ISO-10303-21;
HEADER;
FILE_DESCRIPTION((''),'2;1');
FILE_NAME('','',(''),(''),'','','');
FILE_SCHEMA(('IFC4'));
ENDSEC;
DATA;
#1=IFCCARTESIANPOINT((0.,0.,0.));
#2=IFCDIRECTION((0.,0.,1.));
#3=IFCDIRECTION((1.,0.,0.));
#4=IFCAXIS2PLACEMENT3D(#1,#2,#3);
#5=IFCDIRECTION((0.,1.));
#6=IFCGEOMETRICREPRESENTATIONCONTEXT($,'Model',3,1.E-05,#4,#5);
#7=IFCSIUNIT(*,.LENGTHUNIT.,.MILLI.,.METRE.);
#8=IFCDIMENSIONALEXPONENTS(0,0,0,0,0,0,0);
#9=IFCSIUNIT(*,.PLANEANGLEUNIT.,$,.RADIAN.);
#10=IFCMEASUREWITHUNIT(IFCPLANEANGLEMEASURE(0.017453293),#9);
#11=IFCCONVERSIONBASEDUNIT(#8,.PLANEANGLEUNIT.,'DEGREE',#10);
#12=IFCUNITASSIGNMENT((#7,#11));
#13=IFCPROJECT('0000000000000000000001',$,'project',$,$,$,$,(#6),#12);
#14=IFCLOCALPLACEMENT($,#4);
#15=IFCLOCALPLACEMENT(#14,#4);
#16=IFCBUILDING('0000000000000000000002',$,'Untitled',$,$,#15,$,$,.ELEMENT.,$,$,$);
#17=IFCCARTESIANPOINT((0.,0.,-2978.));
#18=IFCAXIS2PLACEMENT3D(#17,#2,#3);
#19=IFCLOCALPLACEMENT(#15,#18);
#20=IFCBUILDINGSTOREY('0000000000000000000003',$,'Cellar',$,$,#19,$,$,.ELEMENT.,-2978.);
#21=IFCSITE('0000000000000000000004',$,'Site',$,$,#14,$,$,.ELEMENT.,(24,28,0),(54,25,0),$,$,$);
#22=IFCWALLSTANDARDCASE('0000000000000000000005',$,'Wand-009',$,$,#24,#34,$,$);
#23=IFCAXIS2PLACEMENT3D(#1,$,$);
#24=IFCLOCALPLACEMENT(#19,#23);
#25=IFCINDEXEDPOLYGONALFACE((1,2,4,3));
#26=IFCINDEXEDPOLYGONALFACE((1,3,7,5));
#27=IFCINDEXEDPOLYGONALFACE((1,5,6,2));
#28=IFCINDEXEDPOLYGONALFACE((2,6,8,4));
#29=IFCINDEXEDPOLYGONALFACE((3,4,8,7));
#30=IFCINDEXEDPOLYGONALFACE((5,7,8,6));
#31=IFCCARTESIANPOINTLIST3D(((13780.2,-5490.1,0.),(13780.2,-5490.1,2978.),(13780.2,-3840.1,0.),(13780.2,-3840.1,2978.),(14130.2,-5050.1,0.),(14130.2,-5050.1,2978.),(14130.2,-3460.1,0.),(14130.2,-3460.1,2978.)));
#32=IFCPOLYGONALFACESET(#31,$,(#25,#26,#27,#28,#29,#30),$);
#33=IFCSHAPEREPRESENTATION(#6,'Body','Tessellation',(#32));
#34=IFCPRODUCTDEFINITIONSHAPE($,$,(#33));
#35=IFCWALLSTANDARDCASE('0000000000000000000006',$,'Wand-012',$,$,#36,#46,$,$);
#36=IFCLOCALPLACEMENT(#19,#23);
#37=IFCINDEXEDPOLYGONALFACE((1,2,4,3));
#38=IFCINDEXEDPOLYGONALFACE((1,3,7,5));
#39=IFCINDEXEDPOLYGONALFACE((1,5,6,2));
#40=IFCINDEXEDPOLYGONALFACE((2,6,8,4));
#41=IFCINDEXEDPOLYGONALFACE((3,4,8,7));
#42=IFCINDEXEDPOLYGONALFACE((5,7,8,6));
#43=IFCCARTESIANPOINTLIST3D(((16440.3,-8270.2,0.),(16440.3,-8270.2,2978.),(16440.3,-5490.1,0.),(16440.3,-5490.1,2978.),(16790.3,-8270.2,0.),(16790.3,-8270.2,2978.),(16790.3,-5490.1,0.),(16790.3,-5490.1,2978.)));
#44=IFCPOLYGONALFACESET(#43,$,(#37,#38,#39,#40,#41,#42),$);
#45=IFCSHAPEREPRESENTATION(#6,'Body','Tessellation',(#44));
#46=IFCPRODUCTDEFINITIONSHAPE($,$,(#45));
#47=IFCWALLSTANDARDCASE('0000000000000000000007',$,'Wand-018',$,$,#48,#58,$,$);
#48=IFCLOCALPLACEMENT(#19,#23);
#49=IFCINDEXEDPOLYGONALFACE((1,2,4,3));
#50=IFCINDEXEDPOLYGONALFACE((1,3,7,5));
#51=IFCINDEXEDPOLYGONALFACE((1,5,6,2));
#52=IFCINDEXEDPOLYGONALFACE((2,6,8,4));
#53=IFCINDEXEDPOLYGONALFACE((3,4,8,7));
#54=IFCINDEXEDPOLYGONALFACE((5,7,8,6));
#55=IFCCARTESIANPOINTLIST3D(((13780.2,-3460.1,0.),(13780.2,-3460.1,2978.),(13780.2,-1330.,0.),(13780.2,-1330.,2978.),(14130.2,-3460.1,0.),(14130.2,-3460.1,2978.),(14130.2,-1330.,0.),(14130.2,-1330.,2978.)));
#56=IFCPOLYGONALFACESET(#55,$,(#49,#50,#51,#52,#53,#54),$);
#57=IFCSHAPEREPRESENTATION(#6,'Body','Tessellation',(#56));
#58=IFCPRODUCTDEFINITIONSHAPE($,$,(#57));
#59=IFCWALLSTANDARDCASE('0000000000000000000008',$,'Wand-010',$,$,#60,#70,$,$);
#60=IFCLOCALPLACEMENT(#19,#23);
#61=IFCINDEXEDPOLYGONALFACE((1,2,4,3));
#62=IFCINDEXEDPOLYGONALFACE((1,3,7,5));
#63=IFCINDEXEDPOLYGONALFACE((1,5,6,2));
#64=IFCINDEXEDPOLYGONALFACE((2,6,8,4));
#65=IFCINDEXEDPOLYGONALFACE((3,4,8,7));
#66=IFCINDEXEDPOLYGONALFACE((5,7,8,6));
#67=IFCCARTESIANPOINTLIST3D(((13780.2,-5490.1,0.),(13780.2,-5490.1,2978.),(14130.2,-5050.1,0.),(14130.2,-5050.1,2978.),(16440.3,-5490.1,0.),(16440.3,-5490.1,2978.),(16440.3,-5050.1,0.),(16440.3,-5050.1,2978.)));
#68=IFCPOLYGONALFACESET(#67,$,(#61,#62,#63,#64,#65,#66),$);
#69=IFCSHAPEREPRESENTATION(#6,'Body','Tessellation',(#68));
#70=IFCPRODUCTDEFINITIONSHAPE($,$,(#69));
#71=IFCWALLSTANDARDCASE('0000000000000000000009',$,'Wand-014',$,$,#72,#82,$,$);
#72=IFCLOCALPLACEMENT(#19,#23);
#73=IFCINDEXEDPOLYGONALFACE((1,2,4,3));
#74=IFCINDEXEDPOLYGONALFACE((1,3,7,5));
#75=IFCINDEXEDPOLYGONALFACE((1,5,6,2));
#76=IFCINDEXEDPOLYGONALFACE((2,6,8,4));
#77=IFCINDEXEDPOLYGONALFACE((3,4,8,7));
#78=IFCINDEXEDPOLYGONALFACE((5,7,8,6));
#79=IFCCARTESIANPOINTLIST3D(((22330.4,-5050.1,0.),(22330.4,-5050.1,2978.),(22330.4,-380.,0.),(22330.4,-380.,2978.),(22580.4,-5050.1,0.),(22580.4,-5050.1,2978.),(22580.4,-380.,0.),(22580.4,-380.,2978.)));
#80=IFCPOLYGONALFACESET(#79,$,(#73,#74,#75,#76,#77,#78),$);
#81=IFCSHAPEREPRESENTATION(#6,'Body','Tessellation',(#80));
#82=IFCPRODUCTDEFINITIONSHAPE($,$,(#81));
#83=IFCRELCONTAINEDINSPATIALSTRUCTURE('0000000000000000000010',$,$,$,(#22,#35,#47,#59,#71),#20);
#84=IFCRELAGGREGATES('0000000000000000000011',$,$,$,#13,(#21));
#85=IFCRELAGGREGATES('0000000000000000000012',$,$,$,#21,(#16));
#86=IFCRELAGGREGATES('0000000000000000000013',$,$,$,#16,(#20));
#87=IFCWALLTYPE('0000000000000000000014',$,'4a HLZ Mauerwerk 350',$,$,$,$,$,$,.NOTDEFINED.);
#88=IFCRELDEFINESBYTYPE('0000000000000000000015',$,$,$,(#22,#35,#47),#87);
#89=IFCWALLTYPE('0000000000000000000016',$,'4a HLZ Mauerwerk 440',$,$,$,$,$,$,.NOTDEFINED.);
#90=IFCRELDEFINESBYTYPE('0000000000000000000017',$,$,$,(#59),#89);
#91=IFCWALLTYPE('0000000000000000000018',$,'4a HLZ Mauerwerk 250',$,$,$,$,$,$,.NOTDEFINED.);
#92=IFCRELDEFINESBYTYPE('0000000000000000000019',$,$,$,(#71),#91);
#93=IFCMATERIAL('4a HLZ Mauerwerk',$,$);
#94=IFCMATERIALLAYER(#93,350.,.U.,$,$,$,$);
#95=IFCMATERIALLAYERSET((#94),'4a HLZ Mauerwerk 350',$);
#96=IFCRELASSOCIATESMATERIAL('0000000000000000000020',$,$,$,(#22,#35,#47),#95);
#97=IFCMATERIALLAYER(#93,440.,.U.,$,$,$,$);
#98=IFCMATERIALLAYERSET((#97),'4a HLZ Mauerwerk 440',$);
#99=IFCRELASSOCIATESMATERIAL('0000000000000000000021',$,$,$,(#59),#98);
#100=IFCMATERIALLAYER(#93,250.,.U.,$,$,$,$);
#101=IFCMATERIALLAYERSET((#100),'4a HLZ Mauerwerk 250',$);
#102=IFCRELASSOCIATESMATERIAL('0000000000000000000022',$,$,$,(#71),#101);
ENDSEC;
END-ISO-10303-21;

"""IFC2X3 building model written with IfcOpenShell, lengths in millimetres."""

from ifc_helpers import new_model, entity, si_unit, converted_unit, direction, frame, origin_with_axes, place, context, project, spatial, polyline, outline, extrude, material, layer, layer_set, layer_usage, type_object, element, save


model = new_model("IFC2X3")

# Units and contexts
model_context = context("Model", 3, precision=1e-05, world=origin_with_axes(), true_north=direction((0.0, 1.0)))
ifc_project = project(units=[si_unit("LENGTHUNIT", "METRE", prefix="MILLI"), converted_unit("PLANEANGLEUNIT", "DEGREE", entity("IfcPlaneAngleMeasure", 0.017453293), si_unit("PLANEANGLEUNIT", "RADIAN"), dimensions=[0, 0, 0, 0, 0, 0, 0])], contexts=[model_context])

# Site, building, storey
site_placement = place(None, origin_with_axes())
site = spatial("IfcSite", under=ifc_project, at=site_placement, Name="Site", CompositionType="ELEMENT", RefLatitude=(24, 28, 0), RefLongitude=(54, 25, 0))
building_placement = place(site_placement, origin_with_axes())
building = spatial("IfcBuilding", under=site, at=building_placement, Name="Untitled", CompositionType="ELEMENT")
storey_placement = place(building_placement, frame((0.0, 0.0, -2978.0), z_axis=(0.0, 0.0, 1.0), x_axis=(1.0, 0.0, 0.0)))
storey = spatial("IfcBuildingStorey", under=building, at=storey_placement, Name="Cellar", CompositionType="ELEMENT", Elevation=-2978.0)

# Shared definitions
ifc_material_1 = material(Name="4a HLZ Mauerwerk")

# Walls
ifc_layer_1 = layer(ifc_material_1, 350.0, ventilated="UNKNOWN")
ifc_layer_set_1 = layer_set([ifc_layer_1], Name="4a HLZ Mauerwerk 350")
wall_type_1 = type_object("IfcWallType", Name="4a HLZ Mauerwerk 350", PredefinedType="NOTDEFINED")
ifc_layer_usage_1 = layer_usage(ifc_layer_set_1, "AXIS2", "POSITIVE", 0.0)
wall_1_placement = place(storey_placement, frame((13780.2, -3840.1, 0.0), z_axis=(0.0, 0.0, 1.0), x_axis=(0.0, -1.0, 0.0)))
element("IfcWallStandardCase", 1, at=wall_1_placement, inside=storey, type_object=wall_type_1, material=ifc_layer_usage_1, Name="Wand-009", context=model_context, shape_type="SweptSolid", body=[
    extrude(outline(polyline([(0.0, 0.0), (1650.0, 0.0), (1210.0, 350.0), (-380.0, 350.0), (0.0, 0.0)])), origin_with_axes(), (0.0, 0.0, 1.0), 2978.0),
])
ifc_layer_usage_2 = layer_usage(ifc_layer_set_1, "AXIS2", "POSITIVE", 0.0)
wall_2_placement = place(storey_placement, frame((16440.3, -5490.1, 0.0), z_axis=(0.0, 0.0, 1.0), x_axis=(0.0, -1.0, 0.0)))
element("IfcWallStandardCase", 2, at=wall_2_placement, inside=storey, type_object=wall_type_1, material=ifc_layer_usage_2, Name="Wand-012", context=model_context, shape_type="SweptSolid", body=[
    extrude(outline(polyline([(0.0, 0.0), (2780.1, 0.0), (2780.1, 350.0), (0.0, 350.0), (0.0, 0.0)])), origin_with_axes(), (0.0, 0.0, 1.0), 2978.0),
])
ifc_layer_usage_3 = layer_usage(ifc_layer_set_1, "AXIS2", "POSITIVE", 0.0)
wall_3_placement = place(storey_placement, frame((13780.2, -1330.0, 0.0), z_axis=(0.0, 0.0, 1.0), x_axis=(0.0, -1.0, 0.0)))
element("IfcWallStandardCase", 3, at=wall_3_placement, inside=storey, type_object=wall_type_1, material=ifc_layer_usage_3, Name="Wand-018", context=model_context, shape_type="SweptSolid", body=[
    extrude(outline(polyline([(0.0, 0.0), (2130.0, 0.0), (2130.0, 350.0), (0.0, 350.0), (0.0, 0.0)])), origin_with_axes(), (0.0, 0.0, 1.0), 2978.0),
])
ifc_layer_2 = layer(ifc_material_1, 440.0, ventilated="UNKNOWN")
ifc_layer_set_2 = layer_set([ifc_layer_2], Name="4a HLZ Mauerwerk 440")
ifc_layer_usage_4 = layer_usage(ifc_layer_set_2, "AXIS2", "POSITIVE", 0.0)
wall_type_2 = type_object("IfcWallType", Name="4a HLZ Mauerwerk 440", PredefinedType="NOTDEFINED")
wall_4_placement = place(storey_placement, frame((13780.2, -5490.1, 0.0), z_axis=(0.0, 0.0, 1.0), x_axis=(1.0, 0.0, 0.0)))
element("IfcWallStandardCase", 4, at=wall_4_placement, inside=storey, type_object=wall_type_2, material=ifc_layer_usage_4, Name="Wand-010", context=model_context, shape_type="SweptSolid", body=[
    extrude(outline(polyline([(0.0, 0.0), (2660.1, 0.0), (2660.1, 440.0), (350.0, 440.0), (0.0, 0.0)])), origin_with_axes(), (0.0, 0.0, 1.0), 2978.0),
])

# Wall
ifc_layer_3 = layer(ifc_material_1, 250.0, ventilated="UNKNOWN")
ifc_layer_set_3 = layer_set([ifc_layer_3], Name="4a HLZ Mauerwerk 250")
ifc_layer_usage_5 = layer_usage(ifc_layer_set_3, "AXIS2", "POSITIVE", 0.0)
wall_type_3 = type_object("IfcWallType", Name="4a HLZ Mauerwerk 250", PredefinedType="NOTDEFINED")
wall_5_placement = place(storey_placement, frame((22330.4, 0.0, 0.0), z_axis=(0.0, 0.0, 1.0), x_axis=(0.0, -1.0, 0.0)))
element("IfcWallStandardCase", 5, at=wall_5_placement, inside=storey, type_object=wall_type_3, material=ifc_layer_usage_5, Name="Wand-014", context=model_context, shape_type="SweptSolid", body=[
    extrude(outline(polyline([(380.0, 0.0), (5050.1, 0.0), (5050.1, 250.0), (380.0, 250.0), (380.0, 0.0)])), origin_with_axes(), (0.0, 0.0, 1.0), 2978.0),
])

save(model, "model.ifc")
